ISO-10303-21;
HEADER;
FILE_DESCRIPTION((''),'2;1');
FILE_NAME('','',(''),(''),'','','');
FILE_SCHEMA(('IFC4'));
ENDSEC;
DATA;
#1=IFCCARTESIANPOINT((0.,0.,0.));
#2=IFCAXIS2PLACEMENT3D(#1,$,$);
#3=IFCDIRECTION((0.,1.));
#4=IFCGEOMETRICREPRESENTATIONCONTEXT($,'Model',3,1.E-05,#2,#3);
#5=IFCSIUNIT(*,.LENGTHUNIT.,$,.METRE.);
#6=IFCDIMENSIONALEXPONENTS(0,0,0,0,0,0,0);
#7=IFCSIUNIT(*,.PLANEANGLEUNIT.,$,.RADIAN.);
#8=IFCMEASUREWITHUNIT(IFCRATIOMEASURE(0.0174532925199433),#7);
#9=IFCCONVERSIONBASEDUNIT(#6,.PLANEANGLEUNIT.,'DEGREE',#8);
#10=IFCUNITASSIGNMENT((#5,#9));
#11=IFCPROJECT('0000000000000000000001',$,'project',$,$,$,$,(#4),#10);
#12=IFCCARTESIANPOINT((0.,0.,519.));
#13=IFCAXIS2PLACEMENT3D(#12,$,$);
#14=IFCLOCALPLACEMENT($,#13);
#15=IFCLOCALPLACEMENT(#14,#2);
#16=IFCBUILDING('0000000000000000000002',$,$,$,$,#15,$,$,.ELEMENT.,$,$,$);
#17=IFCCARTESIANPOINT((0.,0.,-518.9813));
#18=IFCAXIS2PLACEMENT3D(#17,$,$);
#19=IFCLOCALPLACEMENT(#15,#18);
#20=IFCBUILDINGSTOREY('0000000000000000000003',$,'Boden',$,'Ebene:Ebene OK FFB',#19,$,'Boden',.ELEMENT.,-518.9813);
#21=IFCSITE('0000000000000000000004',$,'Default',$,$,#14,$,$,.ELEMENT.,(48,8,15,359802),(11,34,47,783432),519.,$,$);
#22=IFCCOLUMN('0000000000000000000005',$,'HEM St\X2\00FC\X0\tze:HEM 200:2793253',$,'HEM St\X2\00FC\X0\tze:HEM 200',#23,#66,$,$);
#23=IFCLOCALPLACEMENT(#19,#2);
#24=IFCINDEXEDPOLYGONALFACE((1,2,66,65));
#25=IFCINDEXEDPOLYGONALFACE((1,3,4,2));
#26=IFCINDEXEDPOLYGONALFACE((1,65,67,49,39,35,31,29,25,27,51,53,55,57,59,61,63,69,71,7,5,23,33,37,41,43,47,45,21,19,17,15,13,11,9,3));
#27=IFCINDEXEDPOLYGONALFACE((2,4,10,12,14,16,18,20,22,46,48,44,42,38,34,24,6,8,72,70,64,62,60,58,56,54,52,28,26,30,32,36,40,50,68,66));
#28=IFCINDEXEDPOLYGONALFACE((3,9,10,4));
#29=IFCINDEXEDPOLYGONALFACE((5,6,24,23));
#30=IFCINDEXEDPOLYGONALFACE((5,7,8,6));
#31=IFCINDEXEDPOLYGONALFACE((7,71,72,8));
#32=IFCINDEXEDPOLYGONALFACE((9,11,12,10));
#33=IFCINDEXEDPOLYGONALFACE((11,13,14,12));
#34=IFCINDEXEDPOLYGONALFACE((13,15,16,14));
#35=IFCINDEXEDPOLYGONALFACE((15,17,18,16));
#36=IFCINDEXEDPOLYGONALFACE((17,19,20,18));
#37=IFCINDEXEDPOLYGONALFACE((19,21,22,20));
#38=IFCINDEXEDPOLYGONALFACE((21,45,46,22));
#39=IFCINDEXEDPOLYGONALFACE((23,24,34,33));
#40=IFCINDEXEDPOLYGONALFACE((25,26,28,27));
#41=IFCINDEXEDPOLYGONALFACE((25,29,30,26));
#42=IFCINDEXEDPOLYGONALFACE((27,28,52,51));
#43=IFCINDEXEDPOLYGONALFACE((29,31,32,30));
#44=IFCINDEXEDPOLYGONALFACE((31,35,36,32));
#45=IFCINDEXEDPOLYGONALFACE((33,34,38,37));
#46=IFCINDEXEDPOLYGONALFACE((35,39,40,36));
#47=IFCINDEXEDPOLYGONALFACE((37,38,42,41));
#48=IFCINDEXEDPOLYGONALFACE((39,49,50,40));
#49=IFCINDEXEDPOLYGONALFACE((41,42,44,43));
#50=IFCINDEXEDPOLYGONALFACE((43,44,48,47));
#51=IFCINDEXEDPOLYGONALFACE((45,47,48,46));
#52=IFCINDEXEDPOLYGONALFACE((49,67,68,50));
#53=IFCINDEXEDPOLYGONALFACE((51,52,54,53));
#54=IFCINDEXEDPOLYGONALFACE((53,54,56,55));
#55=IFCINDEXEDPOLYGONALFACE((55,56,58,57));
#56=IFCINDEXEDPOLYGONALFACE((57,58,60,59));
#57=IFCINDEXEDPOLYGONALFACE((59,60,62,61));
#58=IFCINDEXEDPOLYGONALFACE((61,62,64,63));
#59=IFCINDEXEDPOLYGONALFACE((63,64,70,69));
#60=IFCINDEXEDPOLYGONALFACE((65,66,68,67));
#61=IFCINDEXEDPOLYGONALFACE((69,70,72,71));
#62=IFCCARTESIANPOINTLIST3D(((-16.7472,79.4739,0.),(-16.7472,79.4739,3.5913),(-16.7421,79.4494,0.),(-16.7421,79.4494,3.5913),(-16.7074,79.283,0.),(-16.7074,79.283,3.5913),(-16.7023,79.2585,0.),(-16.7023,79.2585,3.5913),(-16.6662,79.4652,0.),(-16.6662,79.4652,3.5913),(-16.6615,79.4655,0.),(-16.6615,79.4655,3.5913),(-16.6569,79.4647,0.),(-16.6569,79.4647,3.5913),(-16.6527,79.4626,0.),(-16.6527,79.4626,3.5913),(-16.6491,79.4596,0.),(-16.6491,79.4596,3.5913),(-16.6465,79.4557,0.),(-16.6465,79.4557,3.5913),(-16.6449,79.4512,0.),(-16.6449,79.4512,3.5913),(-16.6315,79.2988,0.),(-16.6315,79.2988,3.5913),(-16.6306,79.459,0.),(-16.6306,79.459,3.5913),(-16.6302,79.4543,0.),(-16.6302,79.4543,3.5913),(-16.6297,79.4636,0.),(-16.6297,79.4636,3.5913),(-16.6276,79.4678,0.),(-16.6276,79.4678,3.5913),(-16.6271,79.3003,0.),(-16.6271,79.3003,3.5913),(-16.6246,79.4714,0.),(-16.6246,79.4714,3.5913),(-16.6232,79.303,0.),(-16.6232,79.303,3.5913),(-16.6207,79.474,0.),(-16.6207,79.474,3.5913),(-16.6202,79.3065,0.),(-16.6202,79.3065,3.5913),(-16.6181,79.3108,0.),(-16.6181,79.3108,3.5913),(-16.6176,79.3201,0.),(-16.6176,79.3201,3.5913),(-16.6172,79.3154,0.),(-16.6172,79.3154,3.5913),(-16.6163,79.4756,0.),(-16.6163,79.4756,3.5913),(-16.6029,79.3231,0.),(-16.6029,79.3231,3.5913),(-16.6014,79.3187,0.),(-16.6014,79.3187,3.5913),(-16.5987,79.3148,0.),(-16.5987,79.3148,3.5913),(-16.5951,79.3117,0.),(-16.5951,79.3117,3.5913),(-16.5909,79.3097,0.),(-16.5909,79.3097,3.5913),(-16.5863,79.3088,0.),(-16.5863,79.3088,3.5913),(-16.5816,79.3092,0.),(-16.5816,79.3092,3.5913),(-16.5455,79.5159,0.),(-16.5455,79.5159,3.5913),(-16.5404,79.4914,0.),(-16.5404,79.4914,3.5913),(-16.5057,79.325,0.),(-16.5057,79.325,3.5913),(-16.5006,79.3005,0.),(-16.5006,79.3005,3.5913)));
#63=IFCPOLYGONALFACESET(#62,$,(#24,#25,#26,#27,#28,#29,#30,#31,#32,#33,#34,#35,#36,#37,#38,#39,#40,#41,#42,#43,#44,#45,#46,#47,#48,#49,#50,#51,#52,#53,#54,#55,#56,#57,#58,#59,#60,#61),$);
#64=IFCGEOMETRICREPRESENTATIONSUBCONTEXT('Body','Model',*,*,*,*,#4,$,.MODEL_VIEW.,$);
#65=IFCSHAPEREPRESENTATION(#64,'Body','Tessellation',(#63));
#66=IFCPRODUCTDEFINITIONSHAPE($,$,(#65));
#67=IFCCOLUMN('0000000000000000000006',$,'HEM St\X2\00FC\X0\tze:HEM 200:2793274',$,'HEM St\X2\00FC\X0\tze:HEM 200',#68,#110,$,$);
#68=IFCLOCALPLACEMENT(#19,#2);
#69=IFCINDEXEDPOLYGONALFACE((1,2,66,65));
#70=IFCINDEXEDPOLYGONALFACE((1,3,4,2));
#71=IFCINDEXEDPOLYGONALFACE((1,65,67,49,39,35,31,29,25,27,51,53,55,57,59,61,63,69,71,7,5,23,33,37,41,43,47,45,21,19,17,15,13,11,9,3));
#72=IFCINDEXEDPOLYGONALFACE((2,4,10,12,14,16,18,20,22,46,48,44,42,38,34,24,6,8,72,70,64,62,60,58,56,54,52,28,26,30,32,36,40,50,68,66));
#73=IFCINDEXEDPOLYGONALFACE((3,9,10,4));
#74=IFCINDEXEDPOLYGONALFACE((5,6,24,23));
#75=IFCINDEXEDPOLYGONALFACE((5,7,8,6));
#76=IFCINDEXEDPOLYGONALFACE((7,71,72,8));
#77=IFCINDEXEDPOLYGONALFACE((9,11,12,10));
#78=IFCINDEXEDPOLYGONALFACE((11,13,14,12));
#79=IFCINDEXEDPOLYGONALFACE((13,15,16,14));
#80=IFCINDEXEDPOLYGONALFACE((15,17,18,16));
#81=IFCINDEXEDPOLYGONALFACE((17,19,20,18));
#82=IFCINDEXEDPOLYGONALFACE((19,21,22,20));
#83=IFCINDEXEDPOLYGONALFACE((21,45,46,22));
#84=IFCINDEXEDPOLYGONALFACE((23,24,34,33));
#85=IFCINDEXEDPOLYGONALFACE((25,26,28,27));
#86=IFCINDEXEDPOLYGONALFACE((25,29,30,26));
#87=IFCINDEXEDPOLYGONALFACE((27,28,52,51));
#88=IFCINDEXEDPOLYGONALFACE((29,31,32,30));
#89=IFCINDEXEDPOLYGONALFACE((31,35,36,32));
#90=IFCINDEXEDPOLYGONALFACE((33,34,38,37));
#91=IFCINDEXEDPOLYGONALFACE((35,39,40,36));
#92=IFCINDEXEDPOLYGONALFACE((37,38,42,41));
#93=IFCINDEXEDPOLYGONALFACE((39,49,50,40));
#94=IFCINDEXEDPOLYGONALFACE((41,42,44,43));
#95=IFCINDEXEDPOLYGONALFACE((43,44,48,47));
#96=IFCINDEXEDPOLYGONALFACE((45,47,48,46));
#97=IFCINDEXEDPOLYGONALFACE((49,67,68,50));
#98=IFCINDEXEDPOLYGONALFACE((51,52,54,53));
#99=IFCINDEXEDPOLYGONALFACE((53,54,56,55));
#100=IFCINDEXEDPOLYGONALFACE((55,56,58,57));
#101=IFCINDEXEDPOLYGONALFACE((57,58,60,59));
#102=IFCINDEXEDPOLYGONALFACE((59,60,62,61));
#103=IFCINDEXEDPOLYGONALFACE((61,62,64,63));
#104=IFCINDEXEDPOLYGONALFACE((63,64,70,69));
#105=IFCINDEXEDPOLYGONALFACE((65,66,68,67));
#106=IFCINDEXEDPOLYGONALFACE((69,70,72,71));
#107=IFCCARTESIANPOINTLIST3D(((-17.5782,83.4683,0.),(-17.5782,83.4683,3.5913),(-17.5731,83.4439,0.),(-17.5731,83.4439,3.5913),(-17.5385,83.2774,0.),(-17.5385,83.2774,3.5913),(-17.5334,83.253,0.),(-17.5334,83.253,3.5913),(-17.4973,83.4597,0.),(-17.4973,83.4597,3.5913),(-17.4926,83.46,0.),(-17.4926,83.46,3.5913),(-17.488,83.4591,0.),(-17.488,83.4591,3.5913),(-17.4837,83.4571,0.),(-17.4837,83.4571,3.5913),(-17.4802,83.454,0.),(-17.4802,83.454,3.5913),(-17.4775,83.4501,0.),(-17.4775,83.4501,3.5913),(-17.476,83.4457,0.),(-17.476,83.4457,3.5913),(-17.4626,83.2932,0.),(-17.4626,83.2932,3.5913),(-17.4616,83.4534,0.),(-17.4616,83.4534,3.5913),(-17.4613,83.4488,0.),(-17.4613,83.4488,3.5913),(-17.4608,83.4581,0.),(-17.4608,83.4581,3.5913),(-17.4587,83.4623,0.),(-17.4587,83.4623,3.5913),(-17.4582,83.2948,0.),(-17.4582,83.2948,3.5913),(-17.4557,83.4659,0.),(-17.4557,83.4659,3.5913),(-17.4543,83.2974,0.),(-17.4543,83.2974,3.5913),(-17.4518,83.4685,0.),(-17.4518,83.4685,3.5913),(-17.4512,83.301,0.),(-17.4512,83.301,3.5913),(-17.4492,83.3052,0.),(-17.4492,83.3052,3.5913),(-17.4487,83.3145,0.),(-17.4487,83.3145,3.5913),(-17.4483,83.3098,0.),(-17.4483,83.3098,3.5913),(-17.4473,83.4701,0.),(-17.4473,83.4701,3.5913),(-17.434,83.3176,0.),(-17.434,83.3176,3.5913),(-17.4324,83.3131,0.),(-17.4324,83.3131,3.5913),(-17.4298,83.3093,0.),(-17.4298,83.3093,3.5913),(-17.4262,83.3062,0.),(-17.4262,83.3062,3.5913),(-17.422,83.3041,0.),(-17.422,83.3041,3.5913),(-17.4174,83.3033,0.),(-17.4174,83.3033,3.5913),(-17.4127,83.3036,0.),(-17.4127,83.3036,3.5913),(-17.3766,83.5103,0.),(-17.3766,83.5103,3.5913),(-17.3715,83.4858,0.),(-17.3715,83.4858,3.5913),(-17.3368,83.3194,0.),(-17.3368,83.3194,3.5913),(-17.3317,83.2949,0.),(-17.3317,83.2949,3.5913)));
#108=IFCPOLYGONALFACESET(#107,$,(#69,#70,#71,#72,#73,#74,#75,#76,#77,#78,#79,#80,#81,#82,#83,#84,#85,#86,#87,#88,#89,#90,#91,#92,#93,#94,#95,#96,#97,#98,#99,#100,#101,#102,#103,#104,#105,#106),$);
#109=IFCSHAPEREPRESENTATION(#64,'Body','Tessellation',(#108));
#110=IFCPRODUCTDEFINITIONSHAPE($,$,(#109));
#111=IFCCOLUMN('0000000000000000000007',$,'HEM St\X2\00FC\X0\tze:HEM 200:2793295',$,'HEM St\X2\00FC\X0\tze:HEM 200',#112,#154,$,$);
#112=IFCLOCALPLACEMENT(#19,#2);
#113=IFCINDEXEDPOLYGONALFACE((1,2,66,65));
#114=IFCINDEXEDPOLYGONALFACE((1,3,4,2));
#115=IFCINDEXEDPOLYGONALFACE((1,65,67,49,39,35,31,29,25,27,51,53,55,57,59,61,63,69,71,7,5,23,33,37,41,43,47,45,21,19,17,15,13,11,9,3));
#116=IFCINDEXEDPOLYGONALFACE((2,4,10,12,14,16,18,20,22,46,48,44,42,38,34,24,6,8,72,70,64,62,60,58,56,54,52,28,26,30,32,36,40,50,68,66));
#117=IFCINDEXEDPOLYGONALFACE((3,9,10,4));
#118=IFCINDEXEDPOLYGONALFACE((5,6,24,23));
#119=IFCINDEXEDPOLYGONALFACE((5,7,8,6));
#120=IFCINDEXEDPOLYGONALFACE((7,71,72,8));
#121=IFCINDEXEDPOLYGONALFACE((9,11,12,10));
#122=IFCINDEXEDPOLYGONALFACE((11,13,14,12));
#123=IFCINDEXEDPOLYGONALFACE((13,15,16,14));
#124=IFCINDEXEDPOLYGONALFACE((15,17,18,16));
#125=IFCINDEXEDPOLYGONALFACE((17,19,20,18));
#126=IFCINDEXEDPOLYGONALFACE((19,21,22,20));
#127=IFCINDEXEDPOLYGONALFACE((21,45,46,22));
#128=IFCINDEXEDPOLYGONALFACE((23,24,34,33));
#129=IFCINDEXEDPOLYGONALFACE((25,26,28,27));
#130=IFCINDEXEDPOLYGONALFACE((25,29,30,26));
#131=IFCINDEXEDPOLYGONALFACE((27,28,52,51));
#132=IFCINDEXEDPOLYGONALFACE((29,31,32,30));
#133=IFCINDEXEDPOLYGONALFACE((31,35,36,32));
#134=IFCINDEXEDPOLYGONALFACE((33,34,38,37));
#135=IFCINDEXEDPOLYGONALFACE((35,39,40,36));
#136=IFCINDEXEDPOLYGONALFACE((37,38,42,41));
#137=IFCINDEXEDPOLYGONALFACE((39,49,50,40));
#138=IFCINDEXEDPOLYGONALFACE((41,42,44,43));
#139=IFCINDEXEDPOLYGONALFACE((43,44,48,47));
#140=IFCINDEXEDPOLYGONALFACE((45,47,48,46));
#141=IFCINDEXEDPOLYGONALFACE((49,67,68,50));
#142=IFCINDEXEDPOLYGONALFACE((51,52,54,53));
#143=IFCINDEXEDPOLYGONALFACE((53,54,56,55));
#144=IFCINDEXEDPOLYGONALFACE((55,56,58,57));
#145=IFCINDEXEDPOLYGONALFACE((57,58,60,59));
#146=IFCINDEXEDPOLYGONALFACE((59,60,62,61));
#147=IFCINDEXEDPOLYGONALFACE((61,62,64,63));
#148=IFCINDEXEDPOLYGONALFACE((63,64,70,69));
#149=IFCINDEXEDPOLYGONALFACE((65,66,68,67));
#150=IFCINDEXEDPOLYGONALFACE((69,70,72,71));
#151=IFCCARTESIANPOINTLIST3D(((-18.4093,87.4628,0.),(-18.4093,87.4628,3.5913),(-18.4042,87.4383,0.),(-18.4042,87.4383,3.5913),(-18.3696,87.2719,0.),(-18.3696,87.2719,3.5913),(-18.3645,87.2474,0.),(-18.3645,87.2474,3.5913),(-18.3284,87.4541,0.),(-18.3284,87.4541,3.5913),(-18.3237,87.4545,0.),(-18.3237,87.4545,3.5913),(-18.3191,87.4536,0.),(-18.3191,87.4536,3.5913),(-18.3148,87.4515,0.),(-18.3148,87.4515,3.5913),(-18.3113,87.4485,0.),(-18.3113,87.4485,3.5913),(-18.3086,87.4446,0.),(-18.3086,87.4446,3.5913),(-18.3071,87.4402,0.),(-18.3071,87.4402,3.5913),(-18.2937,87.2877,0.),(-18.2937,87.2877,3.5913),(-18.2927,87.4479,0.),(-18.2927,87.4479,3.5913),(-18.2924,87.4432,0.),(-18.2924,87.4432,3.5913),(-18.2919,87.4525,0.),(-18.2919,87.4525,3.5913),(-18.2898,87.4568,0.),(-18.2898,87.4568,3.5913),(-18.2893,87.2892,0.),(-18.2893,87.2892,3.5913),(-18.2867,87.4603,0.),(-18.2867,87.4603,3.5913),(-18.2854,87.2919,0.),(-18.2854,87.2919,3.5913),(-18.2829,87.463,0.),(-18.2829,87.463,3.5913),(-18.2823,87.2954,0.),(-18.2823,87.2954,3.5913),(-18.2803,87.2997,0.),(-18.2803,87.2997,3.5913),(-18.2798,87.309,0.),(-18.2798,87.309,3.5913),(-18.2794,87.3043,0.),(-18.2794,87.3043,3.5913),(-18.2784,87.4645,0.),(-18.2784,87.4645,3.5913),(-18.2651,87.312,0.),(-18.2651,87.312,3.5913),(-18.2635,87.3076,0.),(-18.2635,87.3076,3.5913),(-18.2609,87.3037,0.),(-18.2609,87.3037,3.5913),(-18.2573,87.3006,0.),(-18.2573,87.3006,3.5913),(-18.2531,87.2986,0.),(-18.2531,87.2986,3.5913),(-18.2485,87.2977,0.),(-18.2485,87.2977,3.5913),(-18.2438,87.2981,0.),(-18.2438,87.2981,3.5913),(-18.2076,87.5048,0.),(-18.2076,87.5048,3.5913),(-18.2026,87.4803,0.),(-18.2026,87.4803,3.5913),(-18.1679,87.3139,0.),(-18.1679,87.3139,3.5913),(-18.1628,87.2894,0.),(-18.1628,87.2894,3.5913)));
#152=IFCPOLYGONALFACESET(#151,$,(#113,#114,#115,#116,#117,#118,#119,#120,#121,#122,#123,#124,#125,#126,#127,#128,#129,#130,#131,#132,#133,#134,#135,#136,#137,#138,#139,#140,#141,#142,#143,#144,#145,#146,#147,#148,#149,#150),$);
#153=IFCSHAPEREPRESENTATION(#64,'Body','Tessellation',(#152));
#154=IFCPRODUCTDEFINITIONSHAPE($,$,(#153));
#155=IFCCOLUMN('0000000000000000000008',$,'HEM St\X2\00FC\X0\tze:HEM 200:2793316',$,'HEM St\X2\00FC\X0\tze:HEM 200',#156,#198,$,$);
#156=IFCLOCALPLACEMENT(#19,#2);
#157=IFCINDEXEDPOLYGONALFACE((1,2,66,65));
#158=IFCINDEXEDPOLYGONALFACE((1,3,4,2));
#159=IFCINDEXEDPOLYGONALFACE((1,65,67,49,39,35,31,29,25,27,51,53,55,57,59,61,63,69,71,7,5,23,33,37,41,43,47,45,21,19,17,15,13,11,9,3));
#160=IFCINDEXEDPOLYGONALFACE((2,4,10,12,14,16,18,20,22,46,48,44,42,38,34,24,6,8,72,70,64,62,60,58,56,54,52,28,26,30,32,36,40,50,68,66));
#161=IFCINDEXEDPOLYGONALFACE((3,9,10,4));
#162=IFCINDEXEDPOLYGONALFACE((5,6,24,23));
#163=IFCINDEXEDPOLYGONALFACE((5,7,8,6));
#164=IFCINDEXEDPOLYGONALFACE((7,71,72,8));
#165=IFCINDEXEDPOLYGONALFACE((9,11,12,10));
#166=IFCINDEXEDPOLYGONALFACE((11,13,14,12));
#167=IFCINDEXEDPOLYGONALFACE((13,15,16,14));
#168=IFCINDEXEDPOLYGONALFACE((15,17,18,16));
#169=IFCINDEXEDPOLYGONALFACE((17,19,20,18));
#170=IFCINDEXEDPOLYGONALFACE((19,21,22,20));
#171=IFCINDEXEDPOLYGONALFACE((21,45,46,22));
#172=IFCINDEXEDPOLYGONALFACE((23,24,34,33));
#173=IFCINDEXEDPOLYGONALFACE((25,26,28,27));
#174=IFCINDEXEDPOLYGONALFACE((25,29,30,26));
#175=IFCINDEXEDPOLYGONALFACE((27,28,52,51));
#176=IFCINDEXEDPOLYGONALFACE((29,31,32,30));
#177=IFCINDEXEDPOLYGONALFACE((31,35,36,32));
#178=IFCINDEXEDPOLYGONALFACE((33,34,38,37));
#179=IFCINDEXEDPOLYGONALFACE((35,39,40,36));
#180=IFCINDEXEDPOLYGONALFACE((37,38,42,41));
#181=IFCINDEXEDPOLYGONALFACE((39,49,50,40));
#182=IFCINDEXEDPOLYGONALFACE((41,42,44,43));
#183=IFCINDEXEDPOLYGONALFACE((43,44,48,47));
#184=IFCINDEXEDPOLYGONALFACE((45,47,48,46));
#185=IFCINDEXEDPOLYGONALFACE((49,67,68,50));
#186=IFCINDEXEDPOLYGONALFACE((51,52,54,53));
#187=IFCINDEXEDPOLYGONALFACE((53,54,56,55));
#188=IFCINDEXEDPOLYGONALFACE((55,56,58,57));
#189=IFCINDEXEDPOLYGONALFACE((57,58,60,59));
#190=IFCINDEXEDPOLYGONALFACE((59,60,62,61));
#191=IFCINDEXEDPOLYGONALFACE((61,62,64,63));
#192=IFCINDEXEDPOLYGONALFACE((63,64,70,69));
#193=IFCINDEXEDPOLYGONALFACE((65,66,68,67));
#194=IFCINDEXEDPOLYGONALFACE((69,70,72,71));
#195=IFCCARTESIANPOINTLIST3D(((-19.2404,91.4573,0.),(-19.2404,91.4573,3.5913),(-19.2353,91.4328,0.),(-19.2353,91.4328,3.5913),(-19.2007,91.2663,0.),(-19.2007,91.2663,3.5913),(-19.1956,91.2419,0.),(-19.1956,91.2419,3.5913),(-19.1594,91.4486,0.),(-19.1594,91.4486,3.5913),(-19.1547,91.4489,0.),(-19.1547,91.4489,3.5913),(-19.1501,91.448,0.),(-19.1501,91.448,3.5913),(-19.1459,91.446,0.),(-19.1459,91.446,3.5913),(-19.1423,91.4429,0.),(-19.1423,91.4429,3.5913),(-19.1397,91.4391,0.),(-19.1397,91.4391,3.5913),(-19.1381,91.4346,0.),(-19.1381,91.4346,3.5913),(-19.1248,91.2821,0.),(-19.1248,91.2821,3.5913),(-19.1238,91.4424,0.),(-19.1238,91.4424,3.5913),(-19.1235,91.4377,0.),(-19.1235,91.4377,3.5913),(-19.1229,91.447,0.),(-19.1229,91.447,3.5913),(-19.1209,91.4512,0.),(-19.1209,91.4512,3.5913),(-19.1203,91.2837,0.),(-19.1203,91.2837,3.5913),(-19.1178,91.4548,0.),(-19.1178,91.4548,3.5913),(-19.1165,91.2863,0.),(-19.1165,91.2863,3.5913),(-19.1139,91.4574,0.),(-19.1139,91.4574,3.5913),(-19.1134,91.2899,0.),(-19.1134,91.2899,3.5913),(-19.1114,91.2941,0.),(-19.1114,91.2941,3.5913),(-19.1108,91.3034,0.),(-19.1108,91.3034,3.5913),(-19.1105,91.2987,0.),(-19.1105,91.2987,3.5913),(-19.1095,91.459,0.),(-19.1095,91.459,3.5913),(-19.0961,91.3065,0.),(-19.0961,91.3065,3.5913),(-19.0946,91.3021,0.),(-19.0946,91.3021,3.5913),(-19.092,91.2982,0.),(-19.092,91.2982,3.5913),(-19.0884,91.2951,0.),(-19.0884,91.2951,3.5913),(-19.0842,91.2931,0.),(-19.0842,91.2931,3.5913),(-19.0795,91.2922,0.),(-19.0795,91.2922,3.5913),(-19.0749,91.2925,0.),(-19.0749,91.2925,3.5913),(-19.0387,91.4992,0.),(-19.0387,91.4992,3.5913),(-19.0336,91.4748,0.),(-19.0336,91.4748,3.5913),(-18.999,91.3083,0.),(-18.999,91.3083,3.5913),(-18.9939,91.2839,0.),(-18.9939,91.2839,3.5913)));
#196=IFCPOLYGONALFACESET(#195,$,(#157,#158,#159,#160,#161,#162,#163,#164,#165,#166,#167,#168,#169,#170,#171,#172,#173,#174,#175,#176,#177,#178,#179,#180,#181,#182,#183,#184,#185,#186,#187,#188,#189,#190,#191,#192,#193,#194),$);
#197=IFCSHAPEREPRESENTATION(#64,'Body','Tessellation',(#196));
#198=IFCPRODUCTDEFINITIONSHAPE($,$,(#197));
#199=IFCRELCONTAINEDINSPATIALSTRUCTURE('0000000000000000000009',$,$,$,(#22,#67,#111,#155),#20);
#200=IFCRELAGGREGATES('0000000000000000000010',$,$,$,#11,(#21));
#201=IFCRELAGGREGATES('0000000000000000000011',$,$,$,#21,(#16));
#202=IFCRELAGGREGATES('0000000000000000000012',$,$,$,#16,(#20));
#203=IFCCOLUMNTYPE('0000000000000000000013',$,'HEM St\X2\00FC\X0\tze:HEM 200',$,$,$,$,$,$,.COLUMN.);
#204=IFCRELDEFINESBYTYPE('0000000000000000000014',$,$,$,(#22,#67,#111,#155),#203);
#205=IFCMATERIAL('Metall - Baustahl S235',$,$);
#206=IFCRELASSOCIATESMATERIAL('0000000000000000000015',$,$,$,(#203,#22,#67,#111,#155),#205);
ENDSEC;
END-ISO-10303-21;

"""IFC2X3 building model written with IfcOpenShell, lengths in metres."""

from ifc_helpers import new_model, entity, si_unit, converted_unit, direction, frame, frame_2d, origin, place, context, subcontext, project, spatial, polyline, circle_curve, parameter, trimmed, segment, composite_curve, outline, extrude, source, transform, mapped, material, type_object, type_shapes, element, save


model = new_model("IFC2X3")

# Units and contexts
model_context = context("Model", 3, precision=1e-05, world=origin(), true_north=direction((0.0, 1.0)))
body_context = subcontext(model_context, "Body", "Model", "MODEL_VIEW")
ifc_project = project(units=[si_unit("LENGTHUNIT", "METRE"), converted_unit("PLANEANGLEUNIT", "DEGREE", entity("IfcRatioMeasure", 0.0174532925199433), si_unit("PLANEANGLEUNIT", "RADIAN"), dimensions=[0, 0, 0, 0, 0, 0, 0])], contexts=[model_context])

# Site, building, storey
site_placement = place(None, frame((0.0, 0.0, 519.0)))
site = spatial("IfcSite", under=ifc_project, at=site_placement, Name="Default", CompositionType="ELEMENT", RefLatitude=(48, 8, 15, 359802), RefLongitude=(11, 34, 47, 783432), RefElevation=519.0)
building_placement = place(site_placement, origin())
building = spatial("IfcBuilding", under=site, at=building_placement, CompositionType="ELEMENT")
storey_placement = place(building_placement, frame((0.0, 0.0, -518.9813)))
storey = spatial("IfcBuildingStorey", under=building, at=storey_placement, Name="Boden", ObjectType="Ebene:Ebene OK FFB", LongName="Boden", CompositionType="ELEMENT", Elevation=-518.9813)

# Columns
ifc_material = material(Name="Metall - Baustahl S235")
column_type = type_object("IfcColumnType", Name="HEM Stütze:HEM 200", PredefinedType="COLUMN", material=ifc_material)
shared_shape = source(origin(), body_context, "Body", "SweptSolid", [
    extrude(outline(composite_curve([segment(polyline([(0.085, -0.103), (0.11, -0.103)]), True, "CONTINUOUS"), segment(polyline([(0.11, -0.103), (0.11, 0.103)]), True, "CONTINUOUS"), segment(polyline([(0.11, 0.103), (0.085, 0.103)]), True, "CONTINUOUS"), segment(polyline([(0.085, 0.103), (0.085, 0.0255)]), True, "CONTINUOUS"), segment(trimmed(circle_curve(frame_2d((0.067, 0.0255), x_axis=(1.0, 0.0)), 0.018), [parameter(270.0)], [parameter(0.0)], True, "PARAMETER"), False, "CONTINUOUS"), segment(polyline([(0.067, 0.0075), (-0.067, 0.0075)]), True, "CONTINUOUS"), segment(trimmed(circle_curve(frame_2d((-0.067, 0.0255), x_axis=(0.0, -1.0)), 0.018), [parameter(270.0)], [parameter(0.0)], True, "PARAMETER"), False, "CONTINUOUS"), segment(polyline([(-0.085, 0.0255), (-0.085, 0.103)]), True, "CONTINUOUS"), segment(polyline([(-0.085, 0.103), (-0.11, 0.103)]), True, "CONTINUOUS"), segment(polyline([(-0.11, 0.103), (-0.11, -0.103)]), True, "CONTINUOUS"), segment(polyline([(-0.11, -0.103), (-0.085, -0.103)]), True, "CONTINUOUS"), segment(polyline([(-0.085, -0.103), (-0.085, -0.0255)]), True, "CONTINUOUS"), segment(trimmed(circle_curve(frame_2d((-0.067, -0.0255), x_axis=(-1.0, 0.0)), 0.018), [parameter(270.0)], [parameter(0.0)], True, "PARAMETER"), False, "CONTINUOUS"), segment(polyline([(-0.067, -0.0075), (0.067, -0.0075)]), True, "CONTINUOUS"), segment(trimmed(circle_curve(frame_2d((0.067, -0.0255), x_axis=(0.0, 1.0)), 0.018), [parameter(270.0)], [parameter(0.0)], True, "PARAMETER"), False, "CONTINUOUS"), segment(polyline([(0.085, -0.0255), (0.085, -0.103)]), True, "CONTINUOUS")], self_intersect=False)), frame((0.0, 0.0, -518.9813), z_axis=(0.0, 0.0, 1.0), x_axis=(0.0, -1.0, 0.0)), (0.0, 0.0, 1.0), 3.5913),
])
type_shapes(column_type, [shared_shape])
for number, where, z_axis, x_axis, name in (
    (1, (-16.6239, 79.3872, 518.9813), (0.0, 0.0, 1.0), (0.979008, 0.20382, 0.0), "HEM Stütze:HEM 200:2793253"),
    (2, (-17.455, 83.3816, 518.9813), (0.0, 0.0, 1.0), (0.979008, 0.20382, 0.0), "HEM Stütze:HEM 200:2793274"),
    (3, (-18.2861, 87.3761, 518.9813), (0.0, 0.0, 1.0), (0.979008, 0.20382, 0.0), "HEM Stütze:HEM 200:2793295"),
    (4, (-19.1171, 91.3706, 518.9813), (0.0, 0.0, 1.0), (0.979008, 0.20382, 0.0), "HEM Stütze:HEM 200:2793316"),
):
    element("IfcColumn", number, at=place(storey_placement, frame(where, z_axis=z_axis, x_axis=x_axis)), inside=storey, type_object=column_type, material=ifc_material, Name=name, ObjectType="HEM Stütze:HEM 200", context=body_context, shape_type="MappedRepresentation", body=[
        mapped(shared_shape, transform((0.0, 0.0, 0.0), scale=1.0)),
    ])

save(model, "model.ifc")
